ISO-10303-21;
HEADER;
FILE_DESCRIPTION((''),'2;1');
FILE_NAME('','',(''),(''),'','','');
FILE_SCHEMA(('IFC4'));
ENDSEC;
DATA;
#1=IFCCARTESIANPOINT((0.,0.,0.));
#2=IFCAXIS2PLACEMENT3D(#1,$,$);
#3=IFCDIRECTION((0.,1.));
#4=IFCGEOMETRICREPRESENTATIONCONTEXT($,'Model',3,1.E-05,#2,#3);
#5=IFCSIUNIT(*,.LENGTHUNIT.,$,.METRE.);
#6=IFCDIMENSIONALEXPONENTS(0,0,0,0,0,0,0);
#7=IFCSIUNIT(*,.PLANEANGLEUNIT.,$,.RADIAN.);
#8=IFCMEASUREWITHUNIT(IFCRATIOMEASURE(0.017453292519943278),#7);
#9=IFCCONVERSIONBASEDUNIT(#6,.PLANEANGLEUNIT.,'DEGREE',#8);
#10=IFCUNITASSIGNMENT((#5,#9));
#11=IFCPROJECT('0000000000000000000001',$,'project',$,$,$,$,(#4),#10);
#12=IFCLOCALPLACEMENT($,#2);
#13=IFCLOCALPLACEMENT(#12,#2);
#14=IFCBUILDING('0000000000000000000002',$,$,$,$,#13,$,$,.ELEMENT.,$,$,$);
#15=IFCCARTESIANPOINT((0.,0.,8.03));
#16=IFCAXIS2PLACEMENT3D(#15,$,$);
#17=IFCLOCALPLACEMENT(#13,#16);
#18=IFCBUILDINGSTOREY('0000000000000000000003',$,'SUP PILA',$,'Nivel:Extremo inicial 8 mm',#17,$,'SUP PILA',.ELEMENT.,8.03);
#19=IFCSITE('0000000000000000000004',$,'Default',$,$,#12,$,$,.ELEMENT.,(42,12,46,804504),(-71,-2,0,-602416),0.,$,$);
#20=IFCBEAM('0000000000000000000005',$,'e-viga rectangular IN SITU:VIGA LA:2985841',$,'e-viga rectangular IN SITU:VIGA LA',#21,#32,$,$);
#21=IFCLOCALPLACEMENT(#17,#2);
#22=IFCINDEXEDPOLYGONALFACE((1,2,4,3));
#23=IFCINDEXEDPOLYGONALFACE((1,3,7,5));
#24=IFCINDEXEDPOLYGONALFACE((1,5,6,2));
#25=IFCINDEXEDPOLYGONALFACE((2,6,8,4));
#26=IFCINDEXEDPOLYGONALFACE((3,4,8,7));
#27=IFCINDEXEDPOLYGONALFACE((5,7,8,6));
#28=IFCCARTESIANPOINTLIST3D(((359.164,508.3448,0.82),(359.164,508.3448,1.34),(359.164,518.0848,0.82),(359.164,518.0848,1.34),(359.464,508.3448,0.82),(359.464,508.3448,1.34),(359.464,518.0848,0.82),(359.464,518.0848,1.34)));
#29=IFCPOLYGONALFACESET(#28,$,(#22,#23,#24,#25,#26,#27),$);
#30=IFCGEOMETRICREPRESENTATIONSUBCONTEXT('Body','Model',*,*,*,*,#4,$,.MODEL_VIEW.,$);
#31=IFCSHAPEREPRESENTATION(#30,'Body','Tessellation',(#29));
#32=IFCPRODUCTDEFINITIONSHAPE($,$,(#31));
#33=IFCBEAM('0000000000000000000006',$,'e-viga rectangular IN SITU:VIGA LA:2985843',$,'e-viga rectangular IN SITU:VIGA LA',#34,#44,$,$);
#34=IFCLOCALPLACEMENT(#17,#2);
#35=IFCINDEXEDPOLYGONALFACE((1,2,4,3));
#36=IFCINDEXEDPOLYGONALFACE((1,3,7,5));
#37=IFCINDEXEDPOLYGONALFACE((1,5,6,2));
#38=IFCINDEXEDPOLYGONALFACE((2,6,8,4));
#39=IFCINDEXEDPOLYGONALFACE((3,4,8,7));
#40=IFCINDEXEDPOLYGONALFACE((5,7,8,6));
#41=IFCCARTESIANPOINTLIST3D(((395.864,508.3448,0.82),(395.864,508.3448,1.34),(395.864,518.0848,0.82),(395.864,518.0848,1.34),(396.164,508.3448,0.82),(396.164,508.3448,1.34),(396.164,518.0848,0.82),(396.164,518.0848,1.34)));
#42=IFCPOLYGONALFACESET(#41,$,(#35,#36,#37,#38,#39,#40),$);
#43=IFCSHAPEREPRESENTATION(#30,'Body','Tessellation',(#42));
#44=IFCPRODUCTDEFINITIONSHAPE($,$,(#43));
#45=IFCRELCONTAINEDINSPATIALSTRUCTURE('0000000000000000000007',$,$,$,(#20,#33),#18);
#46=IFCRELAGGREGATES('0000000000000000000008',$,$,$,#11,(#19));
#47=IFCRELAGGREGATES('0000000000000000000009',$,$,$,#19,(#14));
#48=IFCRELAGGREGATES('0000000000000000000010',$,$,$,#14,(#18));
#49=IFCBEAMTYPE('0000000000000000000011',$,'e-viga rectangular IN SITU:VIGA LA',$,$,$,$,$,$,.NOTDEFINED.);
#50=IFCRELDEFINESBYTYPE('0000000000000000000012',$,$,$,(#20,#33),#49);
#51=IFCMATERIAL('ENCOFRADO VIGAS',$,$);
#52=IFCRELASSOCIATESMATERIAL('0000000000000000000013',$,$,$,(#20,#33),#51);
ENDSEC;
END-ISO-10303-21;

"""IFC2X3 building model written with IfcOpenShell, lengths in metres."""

from ifc_helpers import new_model, entity, si_unit, converted_unit, direction, frame, frame_2d, origin, place, context, subcontext, project, spatial, rectangle, extrude, material, type_object, element, save


model = new_model("IFC2X3")

# Units and contexts
model_context = context("Model", 3, precision=1e-05, world=origin(), true_north=direction((0.0, 1.0)))
body_context = subcontext(model_context, "Body", "Model", "MODEL_VIEW")
ifc_project = project(units=[si_unit("LENGTHUNIT", "METRE"), converted_unit("PLANEANGLEUNIT", "DEGREE", entity("IfcRatioMeasure", 0.017453292519943278), si_unit("PLANEANGLEUNIT", "RADIAN"), dimensions=[0, 0, 0, 0, 0, 0, 0])], contexts=[model_context])

# Site, building, storey
site_placement = place(None, origin())
site = spatial("IfcSite", under=ifc_project, at=site_placement, Name="Default", CompositionType="ELEMENT", RefLatitude=(42, 12, 46, 804504), RefLongitude=(-71, -2, 0, -602416), RefElevation=0.0)
building_placement = place(site_placement, origin())
building = spatial("IfcBuilding", under=site, at=building_placement, CompositionType="ELEMENT")
storey_placement = place(building_placement, frame((0.0, 0.0, 8.03)))
storey = spatial("IfcBuildingStorey", under=building, at=storey_placement, Name="SUP PILA", ObjectType="Nivel:Extremo inicial 8 mm", LongName="SUP PILA", CompositionType="ELEMENT", Elevation=8.03)

# Beams
ifc_material_1 = material(Name="ENCOFRADO VIGAS")
beam_type = type_object("IfcBeamType", Name="e-viga rectangular IN SITU:VIGA LA", PredefinedType="NOTDEFINED")
for number, where, z_axis, x_axis, name in (
    (1, (359.314, 508.3448, 0.0), (0.0, 0.0, 1.0), (0.0, 1.0, 0.0), "e-viga rectangular IN SITU:VIGA LA:2985841"),
    (2, (396.014, 508.3448, 0.0), (0.0, 0.0, 1.0), (0.0, 1.0, 0.0), "e-viga rectangular IN SITU:VIGA LA:2985843"),
):
    element("IfcBeam", number, at=place(storey_placement, frame(where, z_axis=z_axis, x_axis=x_axis)), inside=storey, type_object=beam_type, material=ifc_material_1, Name=name, ObjectType="e-viga rectangular IN SITU:VIGA LA", context=body_context, shape_type="SweptSolid", body=[
        extrude(rectangle(XDim=0.52, YDim=0.3, at=frame_2d((0.0, 0.0), x_axis=(1.0, 0.0))), frame((0.0, 0.0, 1.08), z_axis=(1.0, 0.0, 0.0), x_axis=(0.0, 0.0, -1.0)), (0.0, 0.0, 1.0), 9.74),
    ])

save(model, "model.ifc")
